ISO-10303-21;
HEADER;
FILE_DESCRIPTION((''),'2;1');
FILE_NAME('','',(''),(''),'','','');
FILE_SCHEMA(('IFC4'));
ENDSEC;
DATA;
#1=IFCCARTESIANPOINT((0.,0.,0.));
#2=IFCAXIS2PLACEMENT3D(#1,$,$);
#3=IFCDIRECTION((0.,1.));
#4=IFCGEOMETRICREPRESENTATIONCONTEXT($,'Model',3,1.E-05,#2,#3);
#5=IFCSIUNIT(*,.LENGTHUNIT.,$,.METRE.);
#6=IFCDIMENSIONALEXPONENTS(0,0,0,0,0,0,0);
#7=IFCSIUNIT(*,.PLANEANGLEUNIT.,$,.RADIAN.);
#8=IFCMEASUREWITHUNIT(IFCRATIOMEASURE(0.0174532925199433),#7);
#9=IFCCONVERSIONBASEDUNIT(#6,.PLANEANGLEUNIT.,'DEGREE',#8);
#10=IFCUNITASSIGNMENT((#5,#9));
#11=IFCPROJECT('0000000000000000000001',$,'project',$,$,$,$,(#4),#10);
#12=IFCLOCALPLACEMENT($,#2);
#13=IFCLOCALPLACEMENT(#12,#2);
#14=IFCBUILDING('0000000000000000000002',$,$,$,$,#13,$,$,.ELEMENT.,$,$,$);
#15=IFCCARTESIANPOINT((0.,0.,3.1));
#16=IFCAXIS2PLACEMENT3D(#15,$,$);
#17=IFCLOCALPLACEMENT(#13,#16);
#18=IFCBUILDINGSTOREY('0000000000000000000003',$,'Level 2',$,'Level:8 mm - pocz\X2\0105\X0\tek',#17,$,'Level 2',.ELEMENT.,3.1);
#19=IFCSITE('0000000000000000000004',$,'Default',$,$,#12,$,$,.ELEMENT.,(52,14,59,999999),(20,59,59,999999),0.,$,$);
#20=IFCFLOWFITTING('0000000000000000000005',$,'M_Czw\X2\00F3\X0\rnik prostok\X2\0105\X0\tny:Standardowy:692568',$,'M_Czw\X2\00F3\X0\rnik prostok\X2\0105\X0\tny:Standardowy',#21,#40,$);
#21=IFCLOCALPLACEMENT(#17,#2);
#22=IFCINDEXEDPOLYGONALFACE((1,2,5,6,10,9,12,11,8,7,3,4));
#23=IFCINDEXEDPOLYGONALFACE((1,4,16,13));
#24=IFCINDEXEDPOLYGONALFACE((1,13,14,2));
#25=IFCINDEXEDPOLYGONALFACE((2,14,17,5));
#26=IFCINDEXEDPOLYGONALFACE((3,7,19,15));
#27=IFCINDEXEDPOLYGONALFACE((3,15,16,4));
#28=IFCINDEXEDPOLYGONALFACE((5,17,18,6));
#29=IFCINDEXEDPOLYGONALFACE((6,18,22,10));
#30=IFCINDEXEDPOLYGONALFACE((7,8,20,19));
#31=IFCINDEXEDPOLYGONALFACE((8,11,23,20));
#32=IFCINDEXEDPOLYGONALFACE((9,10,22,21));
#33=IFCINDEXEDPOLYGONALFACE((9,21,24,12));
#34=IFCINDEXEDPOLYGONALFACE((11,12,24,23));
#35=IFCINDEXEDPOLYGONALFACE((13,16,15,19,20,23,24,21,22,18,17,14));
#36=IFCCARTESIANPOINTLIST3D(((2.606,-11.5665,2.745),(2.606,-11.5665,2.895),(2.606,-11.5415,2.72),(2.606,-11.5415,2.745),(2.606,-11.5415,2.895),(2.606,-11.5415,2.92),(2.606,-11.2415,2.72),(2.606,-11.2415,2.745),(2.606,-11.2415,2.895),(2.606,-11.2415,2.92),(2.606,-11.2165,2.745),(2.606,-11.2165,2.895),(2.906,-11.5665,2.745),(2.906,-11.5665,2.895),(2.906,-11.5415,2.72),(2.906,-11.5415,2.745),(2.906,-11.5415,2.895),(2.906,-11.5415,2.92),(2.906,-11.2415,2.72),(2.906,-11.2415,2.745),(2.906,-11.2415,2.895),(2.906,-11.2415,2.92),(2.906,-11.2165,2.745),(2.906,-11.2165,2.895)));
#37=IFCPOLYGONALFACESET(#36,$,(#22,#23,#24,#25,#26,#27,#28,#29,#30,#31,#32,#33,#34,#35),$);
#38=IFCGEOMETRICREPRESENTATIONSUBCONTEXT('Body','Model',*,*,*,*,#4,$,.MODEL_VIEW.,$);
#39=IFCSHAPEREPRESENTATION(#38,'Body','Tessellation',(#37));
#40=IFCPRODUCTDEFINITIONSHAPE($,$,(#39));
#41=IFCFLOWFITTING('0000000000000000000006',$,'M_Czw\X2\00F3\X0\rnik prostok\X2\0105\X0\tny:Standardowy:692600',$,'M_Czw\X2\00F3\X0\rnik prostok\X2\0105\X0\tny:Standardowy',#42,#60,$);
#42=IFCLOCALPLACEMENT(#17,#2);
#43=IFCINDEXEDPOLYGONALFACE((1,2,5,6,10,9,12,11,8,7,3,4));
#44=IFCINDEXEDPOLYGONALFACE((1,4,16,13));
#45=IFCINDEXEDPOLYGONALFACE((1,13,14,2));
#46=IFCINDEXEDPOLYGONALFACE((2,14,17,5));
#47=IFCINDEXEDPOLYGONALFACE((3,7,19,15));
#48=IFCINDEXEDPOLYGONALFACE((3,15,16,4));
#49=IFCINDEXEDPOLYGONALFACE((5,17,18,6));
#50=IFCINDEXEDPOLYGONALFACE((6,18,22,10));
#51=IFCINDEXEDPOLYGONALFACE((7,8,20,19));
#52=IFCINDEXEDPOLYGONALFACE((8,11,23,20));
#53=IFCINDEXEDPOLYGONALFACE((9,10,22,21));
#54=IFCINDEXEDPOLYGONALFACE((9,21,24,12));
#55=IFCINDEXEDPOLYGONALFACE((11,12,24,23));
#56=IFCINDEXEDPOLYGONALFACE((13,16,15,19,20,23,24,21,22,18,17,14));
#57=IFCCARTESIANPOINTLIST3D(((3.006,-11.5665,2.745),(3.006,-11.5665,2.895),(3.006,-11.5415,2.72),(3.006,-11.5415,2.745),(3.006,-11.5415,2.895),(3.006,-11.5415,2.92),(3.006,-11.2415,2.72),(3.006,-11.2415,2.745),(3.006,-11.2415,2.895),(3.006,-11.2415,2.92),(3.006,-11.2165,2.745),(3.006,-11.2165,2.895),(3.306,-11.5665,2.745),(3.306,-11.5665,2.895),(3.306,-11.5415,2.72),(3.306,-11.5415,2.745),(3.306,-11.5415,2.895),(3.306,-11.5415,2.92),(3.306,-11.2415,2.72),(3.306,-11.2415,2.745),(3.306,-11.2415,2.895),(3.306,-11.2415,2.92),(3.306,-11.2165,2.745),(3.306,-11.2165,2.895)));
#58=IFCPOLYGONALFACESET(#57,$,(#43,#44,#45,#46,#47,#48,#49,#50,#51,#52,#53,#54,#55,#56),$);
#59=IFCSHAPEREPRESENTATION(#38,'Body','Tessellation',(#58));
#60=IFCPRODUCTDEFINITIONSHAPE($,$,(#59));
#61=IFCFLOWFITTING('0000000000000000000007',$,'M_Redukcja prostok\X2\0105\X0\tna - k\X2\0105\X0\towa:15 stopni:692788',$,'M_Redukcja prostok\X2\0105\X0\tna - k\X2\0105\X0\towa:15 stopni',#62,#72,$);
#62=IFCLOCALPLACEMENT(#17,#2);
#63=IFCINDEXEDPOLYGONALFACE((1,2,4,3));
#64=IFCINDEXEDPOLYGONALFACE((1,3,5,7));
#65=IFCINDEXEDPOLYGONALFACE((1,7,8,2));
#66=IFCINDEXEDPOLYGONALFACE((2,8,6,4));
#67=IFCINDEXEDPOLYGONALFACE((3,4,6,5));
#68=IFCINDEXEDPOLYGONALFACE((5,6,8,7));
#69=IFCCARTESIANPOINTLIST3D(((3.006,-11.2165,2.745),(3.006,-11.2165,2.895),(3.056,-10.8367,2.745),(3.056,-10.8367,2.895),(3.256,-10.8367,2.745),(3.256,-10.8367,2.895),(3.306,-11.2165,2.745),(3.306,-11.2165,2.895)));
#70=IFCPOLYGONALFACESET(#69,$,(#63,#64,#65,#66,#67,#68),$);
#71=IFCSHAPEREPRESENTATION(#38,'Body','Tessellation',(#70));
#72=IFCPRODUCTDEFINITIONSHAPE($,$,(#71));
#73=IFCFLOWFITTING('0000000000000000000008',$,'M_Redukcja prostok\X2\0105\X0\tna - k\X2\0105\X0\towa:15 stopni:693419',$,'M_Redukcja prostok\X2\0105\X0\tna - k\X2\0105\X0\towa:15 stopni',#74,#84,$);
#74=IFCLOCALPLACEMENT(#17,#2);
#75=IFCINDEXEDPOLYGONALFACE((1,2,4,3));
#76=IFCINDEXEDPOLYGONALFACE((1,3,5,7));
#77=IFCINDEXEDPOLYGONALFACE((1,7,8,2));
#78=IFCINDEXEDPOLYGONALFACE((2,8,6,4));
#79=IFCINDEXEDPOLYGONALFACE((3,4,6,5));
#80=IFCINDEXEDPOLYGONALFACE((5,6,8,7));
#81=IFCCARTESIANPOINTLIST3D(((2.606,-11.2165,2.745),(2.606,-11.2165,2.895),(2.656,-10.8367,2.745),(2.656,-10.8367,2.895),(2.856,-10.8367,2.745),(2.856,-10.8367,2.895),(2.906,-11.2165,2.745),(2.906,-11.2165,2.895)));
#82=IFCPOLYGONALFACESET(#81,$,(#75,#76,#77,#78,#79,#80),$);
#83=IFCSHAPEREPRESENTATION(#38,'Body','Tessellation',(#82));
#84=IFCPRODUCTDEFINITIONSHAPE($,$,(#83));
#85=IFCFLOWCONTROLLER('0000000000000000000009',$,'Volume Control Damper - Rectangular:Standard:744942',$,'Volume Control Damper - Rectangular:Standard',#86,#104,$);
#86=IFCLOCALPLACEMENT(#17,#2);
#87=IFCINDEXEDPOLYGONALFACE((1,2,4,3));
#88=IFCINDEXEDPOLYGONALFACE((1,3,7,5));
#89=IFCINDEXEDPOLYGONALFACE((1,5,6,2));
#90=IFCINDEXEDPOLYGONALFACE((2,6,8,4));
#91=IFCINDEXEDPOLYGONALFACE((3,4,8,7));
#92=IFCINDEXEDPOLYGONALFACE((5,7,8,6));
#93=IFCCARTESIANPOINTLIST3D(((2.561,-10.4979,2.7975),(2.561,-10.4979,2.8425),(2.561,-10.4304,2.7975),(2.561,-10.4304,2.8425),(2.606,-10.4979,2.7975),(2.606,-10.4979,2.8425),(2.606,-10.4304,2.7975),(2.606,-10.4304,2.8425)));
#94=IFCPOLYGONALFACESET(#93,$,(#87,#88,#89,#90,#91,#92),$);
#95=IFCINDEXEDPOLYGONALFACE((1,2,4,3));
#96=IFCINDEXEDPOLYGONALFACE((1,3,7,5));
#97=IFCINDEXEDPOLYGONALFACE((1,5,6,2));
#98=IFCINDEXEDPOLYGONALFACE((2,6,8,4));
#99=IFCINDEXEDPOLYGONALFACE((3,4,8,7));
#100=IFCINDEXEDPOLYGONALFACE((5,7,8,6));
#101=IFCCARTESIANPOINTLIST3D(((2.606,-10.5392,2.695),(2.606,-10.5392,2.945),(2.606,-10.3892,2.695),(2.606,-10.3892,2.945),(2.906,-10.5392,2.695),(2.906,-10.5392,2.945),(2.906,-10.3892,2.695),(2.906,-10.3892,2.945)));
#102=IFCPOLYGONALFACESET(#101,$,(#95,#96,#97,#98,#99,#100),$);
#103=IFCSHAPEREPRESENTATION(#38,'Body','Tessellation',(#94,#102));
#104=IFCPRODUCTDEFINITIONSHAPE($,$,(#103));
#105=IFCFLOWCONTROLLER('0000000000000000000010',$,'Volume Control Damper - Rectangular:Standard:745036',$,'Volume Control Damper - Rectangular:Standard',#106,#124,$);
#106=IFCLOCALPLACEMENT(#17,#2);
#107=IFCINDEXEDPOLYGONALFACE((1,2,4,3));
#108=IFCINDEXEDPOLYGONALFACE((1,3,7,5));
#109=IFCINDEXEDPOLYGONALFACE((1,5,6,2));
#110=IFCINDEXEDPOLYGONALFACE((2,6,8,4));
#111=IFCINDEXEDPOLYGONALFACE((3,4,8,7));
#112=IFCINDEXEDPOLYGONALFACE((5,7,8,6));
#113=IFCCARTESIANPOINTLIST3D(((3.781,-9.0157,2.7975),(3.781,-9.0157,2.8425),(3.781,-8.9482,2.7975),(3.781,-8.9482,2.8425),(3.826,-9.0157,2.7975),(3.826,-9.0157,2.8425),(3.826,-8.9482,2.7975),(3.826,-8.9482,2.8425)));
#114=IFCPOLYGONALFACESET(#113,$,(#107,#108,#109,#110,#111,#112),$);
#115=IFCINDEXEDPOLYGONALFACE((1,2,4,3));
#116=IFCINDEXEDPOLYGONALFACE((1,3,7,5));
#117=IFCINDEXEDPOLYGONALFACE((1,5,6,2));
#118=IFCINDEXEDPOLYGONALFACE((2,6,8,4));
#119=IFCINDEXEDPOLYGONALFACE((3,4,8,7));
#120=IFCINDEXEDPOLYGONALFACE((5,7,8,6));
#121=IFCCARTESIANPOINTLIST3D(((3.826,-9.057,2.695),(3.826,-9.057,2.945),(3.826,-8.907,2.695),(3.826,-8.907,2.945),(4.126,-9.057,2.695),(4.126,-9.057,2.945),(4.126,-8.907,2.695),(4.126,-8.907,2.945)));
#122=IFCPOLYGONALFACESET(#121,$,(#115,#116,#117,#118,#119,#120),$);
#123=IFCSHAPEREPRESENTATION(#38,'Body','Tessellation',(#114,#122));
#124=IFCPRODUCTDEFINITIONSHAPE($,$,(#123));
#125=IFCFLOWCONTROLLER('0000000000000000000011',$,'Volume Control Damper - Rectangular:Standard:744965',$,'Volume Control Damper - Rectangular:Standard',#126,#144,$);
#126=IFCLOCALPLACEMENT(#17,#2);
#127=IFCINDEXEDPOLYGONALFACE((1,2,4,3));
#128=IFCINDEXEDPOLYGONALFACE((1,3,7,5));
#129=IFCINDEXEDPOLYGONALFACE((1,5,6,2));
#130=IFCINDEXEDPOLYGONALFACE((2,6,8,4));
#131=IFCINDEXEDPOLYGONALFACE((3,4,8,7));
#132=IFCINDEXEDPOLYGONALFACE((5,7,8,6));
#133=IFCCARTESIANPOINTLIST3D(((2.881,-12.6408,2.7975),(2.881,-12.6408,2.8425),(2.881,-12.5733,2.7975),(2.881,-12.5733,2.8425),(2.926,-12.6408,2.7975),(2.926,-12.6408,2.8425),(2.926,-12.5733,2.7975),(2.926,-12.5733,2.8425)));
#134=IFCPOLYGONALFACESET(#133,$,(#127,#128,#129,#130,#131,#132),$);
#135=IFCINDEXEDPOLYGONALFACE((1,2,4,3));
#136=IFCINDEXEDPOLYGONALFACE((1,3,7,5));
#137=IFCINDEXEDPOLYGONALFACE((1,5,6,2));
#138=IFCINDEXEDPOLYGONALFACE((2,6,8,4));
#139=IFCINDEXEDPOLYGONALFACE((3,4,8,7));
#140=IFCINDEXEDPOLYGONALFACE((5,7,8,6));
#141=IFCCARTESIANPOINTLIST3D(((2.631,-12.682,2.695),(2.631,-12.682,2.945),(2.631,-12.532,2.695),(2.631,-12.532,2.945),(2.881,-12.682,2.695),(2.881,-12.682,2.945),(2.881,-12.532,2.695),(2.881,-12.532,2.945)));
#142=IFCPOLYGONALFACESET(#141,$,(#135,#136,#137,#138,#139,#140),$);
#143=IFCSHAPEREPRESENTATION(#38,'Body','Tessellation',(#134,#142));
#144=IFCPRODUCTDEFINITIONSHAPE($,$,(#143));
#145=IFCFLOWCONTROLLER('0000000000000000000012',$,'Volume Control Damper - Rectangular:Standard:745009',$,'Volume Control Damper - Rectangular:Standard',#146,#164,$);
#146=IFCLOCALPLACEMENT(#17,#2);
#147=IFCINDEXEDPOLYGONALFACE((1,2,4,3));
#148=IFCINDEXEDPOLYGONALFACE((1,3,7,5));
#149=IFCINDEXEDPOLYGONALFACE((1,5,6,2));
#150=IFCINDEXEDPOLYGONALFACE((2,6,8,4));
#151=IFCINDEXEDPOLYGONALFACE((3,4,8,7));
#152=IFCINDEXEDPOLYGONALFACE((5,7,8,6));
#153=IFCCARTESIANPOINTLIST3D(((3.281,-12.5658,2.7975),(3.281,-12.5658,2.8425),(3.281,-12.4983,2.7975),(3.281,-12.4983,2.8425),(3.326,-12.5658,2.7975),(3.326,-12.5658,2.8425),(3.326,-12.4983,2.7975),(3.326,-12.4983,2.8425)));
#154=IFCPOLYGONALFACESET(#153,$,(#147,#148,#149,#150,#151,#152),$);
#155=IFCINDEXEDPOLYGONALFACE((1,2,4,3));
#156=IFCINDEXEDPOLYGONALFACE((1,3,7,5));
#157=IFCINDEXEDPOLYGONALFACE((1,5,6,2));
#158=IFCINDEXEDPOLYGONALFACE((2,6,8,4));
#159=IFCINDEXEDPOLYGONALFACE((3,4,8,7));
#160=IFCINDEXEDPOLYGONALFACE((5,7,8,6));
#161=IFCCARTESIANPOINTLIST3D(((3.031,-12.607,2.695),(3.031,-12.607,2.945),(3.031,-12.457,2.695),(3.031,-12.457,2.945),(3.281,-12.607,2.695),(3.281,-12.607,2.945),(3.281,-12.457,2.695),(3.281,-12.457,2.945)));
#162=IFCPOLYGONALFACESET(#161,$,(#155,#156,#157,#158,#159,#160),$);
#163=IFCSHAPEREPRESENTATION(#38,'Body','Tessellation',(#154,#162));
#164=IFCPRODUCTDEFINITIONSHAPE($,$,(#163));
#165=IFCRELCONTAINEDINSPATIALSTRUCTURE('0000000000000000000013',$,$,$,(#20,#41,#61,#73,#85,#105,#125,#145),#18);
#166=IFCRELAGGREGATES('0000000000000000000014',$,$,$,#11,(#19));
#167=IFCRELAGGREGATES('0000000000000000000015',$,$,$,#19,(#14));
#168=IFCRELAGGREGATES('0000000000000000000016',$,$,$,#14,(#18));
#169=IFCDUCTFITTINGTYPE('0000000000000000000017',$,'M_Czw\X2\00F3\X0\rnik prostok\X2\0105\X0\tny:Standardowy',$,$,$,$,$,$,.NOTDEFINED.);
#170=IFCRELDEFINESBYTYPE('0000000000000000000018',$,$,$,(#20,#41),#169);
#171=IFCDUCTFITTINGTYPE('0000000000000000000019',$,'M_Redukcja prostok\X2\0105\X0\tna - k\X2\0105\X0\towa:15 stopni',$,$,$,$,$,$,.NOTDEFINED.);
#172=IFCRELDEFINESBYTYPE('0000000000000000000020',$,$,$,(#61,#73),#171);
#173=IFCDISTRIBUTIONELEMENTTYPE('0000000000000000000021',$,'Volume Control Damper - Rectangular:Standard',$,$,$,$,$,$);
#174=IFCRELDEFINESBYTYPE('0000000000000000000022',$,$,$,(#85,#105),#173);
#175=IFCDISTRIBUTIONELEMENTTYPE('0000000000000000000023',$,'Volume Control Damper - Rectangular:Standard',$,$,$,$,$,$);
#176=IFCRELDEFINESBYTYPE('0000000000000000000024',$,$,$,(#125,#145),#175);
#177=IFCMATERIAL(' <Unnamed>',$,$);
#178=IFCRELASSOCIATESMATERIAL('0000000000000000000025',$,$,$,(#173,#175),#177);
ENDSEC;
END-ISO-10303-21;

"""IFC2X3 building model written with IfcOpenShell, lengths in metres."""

from ifc_helpers import new_model, entity, si_unit, converted_unit, direction, frame, frame_2d, origin, origin_2d_with_axis, place, context, subcontext, project, spatial, polyline, rectangle, outline, extrude, source, transform, mapped, material, type_object, type_shapes, element, save


model = new_model("IFC2X3")

# Units and contexts
model_context = context("Model", 3, precision=1e-05, world=origin(), true_north=direction((0.0, 1.0)))
body_context = subcontext(model_context, "Body", "Model", "MODEL_VIEW")
ifc_project = project(units=[si_unit("LENGTHUNIT", "METRE"), converted_unit("PLANEANGLEUNIT", "DEGREE", entity("IfcRatioMeasure", 0.0174532925199433), si_unit("PLANEANGLEUNIT", "RADIAN"), dimensions=[0, 0, 0, 0, 0, 0, 0])], contexts=[model_context])

# Site, building, storey
site_placement = place(None, origin())
site = spatial("IfcSite", under=ifc_project, at=site_placement, Name="Default", CompositionType="ELEMENT", RefLatitude=(52, 14, 59, 999999), RefLongitude=(20, 59, 59, 999999), RefElevation=0.0)
building_placement = place(site_placement, origin())
building = spatial("IfcBuilding", under=site, at=building_placement, CompositionType="ELEMENT")
storey_placement = place(building_placement, frame((0.0, 0.0, 3.1)))
storey = spatial("IfcBuildingStorey", under=building, at=storey_placement, Name="Level 2", ObjectType="Level:8 mm - początek", LongName="Level 2", CompositionType="ELEMENT", Elevation=3.1)

# Flow fittings
duct_fitting_type_1 = type_object("IfcDuctFittingType", Name="M_Czwórnik prostokątny:Standardowy", PredefinedType="NOTDEFINED")
shared_shape_1 = source(origin(), body_context, "Body", "SweptSolid", [
    extrude(outline(polyline([(-0.175, 0.075), (-0.175, -0.075), (-0.15, -0.075), (-0.15, -0.1), (0.15, -0.1), (0.15, -0.075), (0.175, -0.075), (0.175, 0.075), (0.15, 0.075), (0.15, 0.1), (-0.15, 0.1), (-0.15, 0.075), (-0.175, 0.075)])), frame((0.0, 0.0, -0.15), z_axis=(0.0, 0.0, -1.0), x_axis=(0.0, 1.0, 0.0)), (0.0, 0.0, -1.0), 0.3),
])
type_shapes(duct_fitting_type_1, [shared_shape_1])
for number, where, z_axis, x_axis, name in (
    (1, (2.756, -11.3915, 2.82), (1.0, 0.0, 0.0), (0.0, 0.0, 1.0), "M_Czwórnik prostokątny:Standardowy:692568"),
    (2, (3.156, -11.3915, 2.82), (1.0, 0.0, 0.0), (0.0, 0.0, 1.0), "M_Czwórnik prostokątny:Standardowy:692600"),
):
    element("IfcFlowFitting", number, at=place(storey_placement, frame(where, z_axis=z_axis, x_axis=x_axis)), inside=storey, type_object=duct_fitting_type_1, Name=name, ObjectType="M_Czwórnik prostokątny:Standardowy", context=body_context, shape_type="MappedRepresentation", body=[
        mapped(shared_shape_1, transform((0.0, 0.0, 0.0), scale=1.0)),
    ])
duct_fitting_type_2 = type_object("IfcDuctFittingType", Name="M_Redukcja prostokątna - kątowa:15 stopni", PredefinedType="NOTDEFINED")
shared_shape_2 = source(origin(), body_context, "Body", "SweptSolid", [
    extrude(outline(polyline([(-0.15, -0.1899), (0.15, -0.1899), (0.1, 0.1899), (-0.1, 0.1899), (-0.15, -0.1899)])), frame((0.1899, 0.0, -0.075), z_axis=(0.0, 0.0, 1.0), x_axis=(0.0, -1.0, 0.0)), (0.0, 0.0, 1.0), 0.15),
])
type_shapes(duct_fitting_type_2, [shared_shape_2])
for number, where, z_axis, x_axis, name in (
    (3, (3.156, -11.2165, 2.82), (0.0, 0.0, 1.0), (0.0, 1.0, 0.0), "M_Redukcja prostokątna - kątowa:15 stopni:692788"),
    (4, (2.756, -11.2165, 2.82), (0.0, 0.0, 1.0), (0.0, 1.0, 0.0), "M_Redukcja prostokątna - kątowa:15 stopni:693419"),
):
    element("IfcFlowFitting", number, at=place(storey_placement, frame(where, z_axis=z_axis, x_axis=x_axis)), inside=storey, type_object=duct_fitting_type_2, Name=name, ObjectType="M_Redukcja prostokątna - kątowa:15 stopni", context=body_context, shape_type="MappedRepresentation", body=[
        mapped(shared_shape_2, transform((0.0, 0.0, 0.0), scale=1.0)),
    ])

# Flow controllers
ifc_material = material(Name=" <Unnamed>")
distribution_element_type_1 = type_object("IfcDistributionElementType", Name="Volume Control Damper - Rectangular:Standard", material=ifc_material)
shared_shape_3 = source(origin(), body_context, "Body", "SweptSolid", [
    extrude(rectangle(XDim=0.0675, YDim=0.045, at=frame_2d((0.0, 0.0), x_axis=(1.0, 0.0))), frame((0.0, 0.1725, -0.0225), z_axis=(0.0, 0.0, 1.0), x_axis=(-1.0, 0.0, 0.0)), (0.0, 0.0, 1.0), 0.045),
    extrude(rectangle(XDim=0.15, YDim=0.3, at=origin_2d_with_axis()), frame((0.0, 0.0, -0.125), z_axis=(0.0, 0.0, 1.0), x_axis=(-1.0, 0.0, 0.0)), (0.0, 0.0, 1.0), 0.25),
])
type_shapes(distribution_element_type_1, [shared_shape_3])
for number, where, z_axis, x_axis, name in (
    (5, (2.756, -10.4642, 2.82), (0.0, 0.0, -1.0), (0.0, -1.0, 0.0), "Volume Control Damper - Rectangular:Standard:744942"),
    (6, (3.976, -8.982, 2.82), (0.0, 0.0, -1.0), (0.0, -1.0, 0.0), "Volume Control Damper - Rectangular:Standard:745036"),
):
    element("IfcFlowController", number, at=place(storey_placement, frame(where, z_axis=z_axis, x_axis=x_axis)), inside=storey, type_object=distribution_element_type_1, Name=name, ObjectType="Volume Control Damper - Rectangular:Standard", context=body_context, shape_type="MappedRepresentation", body=[
        mapped(shared_shape_3, transform((0.0, 0.0, 0.0), scale=1.0)),
    ])
distribution_element_type_2 = type_object("IfcDistributionElementType", Name="Volume Control Damper - Rectangular:Standard", material=ifc_material)
shared_shape_4 = source(origin(), body_context, "Body", "SweptSolid", [
    extrude(rectangle(XDim=0.0675, YDim=0.045, at=origin_2d_with_axis()), frame((0.0, 0.1475, -0.0225), z_axis=(0.0, 0.0, 1.0), x_axis=(-1.0, 0.0, 0.0)), (0.0, 0.0, 1.0), 0.045),
    extrude(rectangle(XDim=0.15, YDim=0.25, at=origin_2d_with_axis()), frame((0.0, 0.0, -0.125), z_axis=(0.0, 0.0, 1.0), x_axis=(-1.0, 0.0, 0.0)), (0.0, 0.0, 1.0), 0.25),
])
type_shapes(distribution_element_type_2, [shared_shape_4])
for number, where, z_axis, x_axis, name in (
    (7, (2.756, -12.607, 2.82), (0.0, 0.0, -1.0), (0.0, 1.0, 0.0), "Volume Control Damper - Rectangular:Standard:744965"),
    (8, (3.156, -12.532, 2.82), (0.0, 0.0, -1.0), (0.0, 1.0, 0.0), "Volume Control Damper - Rectangular:Standard:745009"),
):
    element("IfcFlowController", number, at=place(storey_placement, frame(where, z_axis=z_axis, x_axis=x_axis)), inside=storey, type_object=distribution_element_type_2, Name=name, ObjectType="Volume Control Damper - Rectangular:Standard", context=body_context, shape_type="MappedRepresentation", body=[
        mapped(shared_shape_4, transform((0.0, 0.0, 0.0), scale=1.0)),
    ])

save(model, "model.ifc")
